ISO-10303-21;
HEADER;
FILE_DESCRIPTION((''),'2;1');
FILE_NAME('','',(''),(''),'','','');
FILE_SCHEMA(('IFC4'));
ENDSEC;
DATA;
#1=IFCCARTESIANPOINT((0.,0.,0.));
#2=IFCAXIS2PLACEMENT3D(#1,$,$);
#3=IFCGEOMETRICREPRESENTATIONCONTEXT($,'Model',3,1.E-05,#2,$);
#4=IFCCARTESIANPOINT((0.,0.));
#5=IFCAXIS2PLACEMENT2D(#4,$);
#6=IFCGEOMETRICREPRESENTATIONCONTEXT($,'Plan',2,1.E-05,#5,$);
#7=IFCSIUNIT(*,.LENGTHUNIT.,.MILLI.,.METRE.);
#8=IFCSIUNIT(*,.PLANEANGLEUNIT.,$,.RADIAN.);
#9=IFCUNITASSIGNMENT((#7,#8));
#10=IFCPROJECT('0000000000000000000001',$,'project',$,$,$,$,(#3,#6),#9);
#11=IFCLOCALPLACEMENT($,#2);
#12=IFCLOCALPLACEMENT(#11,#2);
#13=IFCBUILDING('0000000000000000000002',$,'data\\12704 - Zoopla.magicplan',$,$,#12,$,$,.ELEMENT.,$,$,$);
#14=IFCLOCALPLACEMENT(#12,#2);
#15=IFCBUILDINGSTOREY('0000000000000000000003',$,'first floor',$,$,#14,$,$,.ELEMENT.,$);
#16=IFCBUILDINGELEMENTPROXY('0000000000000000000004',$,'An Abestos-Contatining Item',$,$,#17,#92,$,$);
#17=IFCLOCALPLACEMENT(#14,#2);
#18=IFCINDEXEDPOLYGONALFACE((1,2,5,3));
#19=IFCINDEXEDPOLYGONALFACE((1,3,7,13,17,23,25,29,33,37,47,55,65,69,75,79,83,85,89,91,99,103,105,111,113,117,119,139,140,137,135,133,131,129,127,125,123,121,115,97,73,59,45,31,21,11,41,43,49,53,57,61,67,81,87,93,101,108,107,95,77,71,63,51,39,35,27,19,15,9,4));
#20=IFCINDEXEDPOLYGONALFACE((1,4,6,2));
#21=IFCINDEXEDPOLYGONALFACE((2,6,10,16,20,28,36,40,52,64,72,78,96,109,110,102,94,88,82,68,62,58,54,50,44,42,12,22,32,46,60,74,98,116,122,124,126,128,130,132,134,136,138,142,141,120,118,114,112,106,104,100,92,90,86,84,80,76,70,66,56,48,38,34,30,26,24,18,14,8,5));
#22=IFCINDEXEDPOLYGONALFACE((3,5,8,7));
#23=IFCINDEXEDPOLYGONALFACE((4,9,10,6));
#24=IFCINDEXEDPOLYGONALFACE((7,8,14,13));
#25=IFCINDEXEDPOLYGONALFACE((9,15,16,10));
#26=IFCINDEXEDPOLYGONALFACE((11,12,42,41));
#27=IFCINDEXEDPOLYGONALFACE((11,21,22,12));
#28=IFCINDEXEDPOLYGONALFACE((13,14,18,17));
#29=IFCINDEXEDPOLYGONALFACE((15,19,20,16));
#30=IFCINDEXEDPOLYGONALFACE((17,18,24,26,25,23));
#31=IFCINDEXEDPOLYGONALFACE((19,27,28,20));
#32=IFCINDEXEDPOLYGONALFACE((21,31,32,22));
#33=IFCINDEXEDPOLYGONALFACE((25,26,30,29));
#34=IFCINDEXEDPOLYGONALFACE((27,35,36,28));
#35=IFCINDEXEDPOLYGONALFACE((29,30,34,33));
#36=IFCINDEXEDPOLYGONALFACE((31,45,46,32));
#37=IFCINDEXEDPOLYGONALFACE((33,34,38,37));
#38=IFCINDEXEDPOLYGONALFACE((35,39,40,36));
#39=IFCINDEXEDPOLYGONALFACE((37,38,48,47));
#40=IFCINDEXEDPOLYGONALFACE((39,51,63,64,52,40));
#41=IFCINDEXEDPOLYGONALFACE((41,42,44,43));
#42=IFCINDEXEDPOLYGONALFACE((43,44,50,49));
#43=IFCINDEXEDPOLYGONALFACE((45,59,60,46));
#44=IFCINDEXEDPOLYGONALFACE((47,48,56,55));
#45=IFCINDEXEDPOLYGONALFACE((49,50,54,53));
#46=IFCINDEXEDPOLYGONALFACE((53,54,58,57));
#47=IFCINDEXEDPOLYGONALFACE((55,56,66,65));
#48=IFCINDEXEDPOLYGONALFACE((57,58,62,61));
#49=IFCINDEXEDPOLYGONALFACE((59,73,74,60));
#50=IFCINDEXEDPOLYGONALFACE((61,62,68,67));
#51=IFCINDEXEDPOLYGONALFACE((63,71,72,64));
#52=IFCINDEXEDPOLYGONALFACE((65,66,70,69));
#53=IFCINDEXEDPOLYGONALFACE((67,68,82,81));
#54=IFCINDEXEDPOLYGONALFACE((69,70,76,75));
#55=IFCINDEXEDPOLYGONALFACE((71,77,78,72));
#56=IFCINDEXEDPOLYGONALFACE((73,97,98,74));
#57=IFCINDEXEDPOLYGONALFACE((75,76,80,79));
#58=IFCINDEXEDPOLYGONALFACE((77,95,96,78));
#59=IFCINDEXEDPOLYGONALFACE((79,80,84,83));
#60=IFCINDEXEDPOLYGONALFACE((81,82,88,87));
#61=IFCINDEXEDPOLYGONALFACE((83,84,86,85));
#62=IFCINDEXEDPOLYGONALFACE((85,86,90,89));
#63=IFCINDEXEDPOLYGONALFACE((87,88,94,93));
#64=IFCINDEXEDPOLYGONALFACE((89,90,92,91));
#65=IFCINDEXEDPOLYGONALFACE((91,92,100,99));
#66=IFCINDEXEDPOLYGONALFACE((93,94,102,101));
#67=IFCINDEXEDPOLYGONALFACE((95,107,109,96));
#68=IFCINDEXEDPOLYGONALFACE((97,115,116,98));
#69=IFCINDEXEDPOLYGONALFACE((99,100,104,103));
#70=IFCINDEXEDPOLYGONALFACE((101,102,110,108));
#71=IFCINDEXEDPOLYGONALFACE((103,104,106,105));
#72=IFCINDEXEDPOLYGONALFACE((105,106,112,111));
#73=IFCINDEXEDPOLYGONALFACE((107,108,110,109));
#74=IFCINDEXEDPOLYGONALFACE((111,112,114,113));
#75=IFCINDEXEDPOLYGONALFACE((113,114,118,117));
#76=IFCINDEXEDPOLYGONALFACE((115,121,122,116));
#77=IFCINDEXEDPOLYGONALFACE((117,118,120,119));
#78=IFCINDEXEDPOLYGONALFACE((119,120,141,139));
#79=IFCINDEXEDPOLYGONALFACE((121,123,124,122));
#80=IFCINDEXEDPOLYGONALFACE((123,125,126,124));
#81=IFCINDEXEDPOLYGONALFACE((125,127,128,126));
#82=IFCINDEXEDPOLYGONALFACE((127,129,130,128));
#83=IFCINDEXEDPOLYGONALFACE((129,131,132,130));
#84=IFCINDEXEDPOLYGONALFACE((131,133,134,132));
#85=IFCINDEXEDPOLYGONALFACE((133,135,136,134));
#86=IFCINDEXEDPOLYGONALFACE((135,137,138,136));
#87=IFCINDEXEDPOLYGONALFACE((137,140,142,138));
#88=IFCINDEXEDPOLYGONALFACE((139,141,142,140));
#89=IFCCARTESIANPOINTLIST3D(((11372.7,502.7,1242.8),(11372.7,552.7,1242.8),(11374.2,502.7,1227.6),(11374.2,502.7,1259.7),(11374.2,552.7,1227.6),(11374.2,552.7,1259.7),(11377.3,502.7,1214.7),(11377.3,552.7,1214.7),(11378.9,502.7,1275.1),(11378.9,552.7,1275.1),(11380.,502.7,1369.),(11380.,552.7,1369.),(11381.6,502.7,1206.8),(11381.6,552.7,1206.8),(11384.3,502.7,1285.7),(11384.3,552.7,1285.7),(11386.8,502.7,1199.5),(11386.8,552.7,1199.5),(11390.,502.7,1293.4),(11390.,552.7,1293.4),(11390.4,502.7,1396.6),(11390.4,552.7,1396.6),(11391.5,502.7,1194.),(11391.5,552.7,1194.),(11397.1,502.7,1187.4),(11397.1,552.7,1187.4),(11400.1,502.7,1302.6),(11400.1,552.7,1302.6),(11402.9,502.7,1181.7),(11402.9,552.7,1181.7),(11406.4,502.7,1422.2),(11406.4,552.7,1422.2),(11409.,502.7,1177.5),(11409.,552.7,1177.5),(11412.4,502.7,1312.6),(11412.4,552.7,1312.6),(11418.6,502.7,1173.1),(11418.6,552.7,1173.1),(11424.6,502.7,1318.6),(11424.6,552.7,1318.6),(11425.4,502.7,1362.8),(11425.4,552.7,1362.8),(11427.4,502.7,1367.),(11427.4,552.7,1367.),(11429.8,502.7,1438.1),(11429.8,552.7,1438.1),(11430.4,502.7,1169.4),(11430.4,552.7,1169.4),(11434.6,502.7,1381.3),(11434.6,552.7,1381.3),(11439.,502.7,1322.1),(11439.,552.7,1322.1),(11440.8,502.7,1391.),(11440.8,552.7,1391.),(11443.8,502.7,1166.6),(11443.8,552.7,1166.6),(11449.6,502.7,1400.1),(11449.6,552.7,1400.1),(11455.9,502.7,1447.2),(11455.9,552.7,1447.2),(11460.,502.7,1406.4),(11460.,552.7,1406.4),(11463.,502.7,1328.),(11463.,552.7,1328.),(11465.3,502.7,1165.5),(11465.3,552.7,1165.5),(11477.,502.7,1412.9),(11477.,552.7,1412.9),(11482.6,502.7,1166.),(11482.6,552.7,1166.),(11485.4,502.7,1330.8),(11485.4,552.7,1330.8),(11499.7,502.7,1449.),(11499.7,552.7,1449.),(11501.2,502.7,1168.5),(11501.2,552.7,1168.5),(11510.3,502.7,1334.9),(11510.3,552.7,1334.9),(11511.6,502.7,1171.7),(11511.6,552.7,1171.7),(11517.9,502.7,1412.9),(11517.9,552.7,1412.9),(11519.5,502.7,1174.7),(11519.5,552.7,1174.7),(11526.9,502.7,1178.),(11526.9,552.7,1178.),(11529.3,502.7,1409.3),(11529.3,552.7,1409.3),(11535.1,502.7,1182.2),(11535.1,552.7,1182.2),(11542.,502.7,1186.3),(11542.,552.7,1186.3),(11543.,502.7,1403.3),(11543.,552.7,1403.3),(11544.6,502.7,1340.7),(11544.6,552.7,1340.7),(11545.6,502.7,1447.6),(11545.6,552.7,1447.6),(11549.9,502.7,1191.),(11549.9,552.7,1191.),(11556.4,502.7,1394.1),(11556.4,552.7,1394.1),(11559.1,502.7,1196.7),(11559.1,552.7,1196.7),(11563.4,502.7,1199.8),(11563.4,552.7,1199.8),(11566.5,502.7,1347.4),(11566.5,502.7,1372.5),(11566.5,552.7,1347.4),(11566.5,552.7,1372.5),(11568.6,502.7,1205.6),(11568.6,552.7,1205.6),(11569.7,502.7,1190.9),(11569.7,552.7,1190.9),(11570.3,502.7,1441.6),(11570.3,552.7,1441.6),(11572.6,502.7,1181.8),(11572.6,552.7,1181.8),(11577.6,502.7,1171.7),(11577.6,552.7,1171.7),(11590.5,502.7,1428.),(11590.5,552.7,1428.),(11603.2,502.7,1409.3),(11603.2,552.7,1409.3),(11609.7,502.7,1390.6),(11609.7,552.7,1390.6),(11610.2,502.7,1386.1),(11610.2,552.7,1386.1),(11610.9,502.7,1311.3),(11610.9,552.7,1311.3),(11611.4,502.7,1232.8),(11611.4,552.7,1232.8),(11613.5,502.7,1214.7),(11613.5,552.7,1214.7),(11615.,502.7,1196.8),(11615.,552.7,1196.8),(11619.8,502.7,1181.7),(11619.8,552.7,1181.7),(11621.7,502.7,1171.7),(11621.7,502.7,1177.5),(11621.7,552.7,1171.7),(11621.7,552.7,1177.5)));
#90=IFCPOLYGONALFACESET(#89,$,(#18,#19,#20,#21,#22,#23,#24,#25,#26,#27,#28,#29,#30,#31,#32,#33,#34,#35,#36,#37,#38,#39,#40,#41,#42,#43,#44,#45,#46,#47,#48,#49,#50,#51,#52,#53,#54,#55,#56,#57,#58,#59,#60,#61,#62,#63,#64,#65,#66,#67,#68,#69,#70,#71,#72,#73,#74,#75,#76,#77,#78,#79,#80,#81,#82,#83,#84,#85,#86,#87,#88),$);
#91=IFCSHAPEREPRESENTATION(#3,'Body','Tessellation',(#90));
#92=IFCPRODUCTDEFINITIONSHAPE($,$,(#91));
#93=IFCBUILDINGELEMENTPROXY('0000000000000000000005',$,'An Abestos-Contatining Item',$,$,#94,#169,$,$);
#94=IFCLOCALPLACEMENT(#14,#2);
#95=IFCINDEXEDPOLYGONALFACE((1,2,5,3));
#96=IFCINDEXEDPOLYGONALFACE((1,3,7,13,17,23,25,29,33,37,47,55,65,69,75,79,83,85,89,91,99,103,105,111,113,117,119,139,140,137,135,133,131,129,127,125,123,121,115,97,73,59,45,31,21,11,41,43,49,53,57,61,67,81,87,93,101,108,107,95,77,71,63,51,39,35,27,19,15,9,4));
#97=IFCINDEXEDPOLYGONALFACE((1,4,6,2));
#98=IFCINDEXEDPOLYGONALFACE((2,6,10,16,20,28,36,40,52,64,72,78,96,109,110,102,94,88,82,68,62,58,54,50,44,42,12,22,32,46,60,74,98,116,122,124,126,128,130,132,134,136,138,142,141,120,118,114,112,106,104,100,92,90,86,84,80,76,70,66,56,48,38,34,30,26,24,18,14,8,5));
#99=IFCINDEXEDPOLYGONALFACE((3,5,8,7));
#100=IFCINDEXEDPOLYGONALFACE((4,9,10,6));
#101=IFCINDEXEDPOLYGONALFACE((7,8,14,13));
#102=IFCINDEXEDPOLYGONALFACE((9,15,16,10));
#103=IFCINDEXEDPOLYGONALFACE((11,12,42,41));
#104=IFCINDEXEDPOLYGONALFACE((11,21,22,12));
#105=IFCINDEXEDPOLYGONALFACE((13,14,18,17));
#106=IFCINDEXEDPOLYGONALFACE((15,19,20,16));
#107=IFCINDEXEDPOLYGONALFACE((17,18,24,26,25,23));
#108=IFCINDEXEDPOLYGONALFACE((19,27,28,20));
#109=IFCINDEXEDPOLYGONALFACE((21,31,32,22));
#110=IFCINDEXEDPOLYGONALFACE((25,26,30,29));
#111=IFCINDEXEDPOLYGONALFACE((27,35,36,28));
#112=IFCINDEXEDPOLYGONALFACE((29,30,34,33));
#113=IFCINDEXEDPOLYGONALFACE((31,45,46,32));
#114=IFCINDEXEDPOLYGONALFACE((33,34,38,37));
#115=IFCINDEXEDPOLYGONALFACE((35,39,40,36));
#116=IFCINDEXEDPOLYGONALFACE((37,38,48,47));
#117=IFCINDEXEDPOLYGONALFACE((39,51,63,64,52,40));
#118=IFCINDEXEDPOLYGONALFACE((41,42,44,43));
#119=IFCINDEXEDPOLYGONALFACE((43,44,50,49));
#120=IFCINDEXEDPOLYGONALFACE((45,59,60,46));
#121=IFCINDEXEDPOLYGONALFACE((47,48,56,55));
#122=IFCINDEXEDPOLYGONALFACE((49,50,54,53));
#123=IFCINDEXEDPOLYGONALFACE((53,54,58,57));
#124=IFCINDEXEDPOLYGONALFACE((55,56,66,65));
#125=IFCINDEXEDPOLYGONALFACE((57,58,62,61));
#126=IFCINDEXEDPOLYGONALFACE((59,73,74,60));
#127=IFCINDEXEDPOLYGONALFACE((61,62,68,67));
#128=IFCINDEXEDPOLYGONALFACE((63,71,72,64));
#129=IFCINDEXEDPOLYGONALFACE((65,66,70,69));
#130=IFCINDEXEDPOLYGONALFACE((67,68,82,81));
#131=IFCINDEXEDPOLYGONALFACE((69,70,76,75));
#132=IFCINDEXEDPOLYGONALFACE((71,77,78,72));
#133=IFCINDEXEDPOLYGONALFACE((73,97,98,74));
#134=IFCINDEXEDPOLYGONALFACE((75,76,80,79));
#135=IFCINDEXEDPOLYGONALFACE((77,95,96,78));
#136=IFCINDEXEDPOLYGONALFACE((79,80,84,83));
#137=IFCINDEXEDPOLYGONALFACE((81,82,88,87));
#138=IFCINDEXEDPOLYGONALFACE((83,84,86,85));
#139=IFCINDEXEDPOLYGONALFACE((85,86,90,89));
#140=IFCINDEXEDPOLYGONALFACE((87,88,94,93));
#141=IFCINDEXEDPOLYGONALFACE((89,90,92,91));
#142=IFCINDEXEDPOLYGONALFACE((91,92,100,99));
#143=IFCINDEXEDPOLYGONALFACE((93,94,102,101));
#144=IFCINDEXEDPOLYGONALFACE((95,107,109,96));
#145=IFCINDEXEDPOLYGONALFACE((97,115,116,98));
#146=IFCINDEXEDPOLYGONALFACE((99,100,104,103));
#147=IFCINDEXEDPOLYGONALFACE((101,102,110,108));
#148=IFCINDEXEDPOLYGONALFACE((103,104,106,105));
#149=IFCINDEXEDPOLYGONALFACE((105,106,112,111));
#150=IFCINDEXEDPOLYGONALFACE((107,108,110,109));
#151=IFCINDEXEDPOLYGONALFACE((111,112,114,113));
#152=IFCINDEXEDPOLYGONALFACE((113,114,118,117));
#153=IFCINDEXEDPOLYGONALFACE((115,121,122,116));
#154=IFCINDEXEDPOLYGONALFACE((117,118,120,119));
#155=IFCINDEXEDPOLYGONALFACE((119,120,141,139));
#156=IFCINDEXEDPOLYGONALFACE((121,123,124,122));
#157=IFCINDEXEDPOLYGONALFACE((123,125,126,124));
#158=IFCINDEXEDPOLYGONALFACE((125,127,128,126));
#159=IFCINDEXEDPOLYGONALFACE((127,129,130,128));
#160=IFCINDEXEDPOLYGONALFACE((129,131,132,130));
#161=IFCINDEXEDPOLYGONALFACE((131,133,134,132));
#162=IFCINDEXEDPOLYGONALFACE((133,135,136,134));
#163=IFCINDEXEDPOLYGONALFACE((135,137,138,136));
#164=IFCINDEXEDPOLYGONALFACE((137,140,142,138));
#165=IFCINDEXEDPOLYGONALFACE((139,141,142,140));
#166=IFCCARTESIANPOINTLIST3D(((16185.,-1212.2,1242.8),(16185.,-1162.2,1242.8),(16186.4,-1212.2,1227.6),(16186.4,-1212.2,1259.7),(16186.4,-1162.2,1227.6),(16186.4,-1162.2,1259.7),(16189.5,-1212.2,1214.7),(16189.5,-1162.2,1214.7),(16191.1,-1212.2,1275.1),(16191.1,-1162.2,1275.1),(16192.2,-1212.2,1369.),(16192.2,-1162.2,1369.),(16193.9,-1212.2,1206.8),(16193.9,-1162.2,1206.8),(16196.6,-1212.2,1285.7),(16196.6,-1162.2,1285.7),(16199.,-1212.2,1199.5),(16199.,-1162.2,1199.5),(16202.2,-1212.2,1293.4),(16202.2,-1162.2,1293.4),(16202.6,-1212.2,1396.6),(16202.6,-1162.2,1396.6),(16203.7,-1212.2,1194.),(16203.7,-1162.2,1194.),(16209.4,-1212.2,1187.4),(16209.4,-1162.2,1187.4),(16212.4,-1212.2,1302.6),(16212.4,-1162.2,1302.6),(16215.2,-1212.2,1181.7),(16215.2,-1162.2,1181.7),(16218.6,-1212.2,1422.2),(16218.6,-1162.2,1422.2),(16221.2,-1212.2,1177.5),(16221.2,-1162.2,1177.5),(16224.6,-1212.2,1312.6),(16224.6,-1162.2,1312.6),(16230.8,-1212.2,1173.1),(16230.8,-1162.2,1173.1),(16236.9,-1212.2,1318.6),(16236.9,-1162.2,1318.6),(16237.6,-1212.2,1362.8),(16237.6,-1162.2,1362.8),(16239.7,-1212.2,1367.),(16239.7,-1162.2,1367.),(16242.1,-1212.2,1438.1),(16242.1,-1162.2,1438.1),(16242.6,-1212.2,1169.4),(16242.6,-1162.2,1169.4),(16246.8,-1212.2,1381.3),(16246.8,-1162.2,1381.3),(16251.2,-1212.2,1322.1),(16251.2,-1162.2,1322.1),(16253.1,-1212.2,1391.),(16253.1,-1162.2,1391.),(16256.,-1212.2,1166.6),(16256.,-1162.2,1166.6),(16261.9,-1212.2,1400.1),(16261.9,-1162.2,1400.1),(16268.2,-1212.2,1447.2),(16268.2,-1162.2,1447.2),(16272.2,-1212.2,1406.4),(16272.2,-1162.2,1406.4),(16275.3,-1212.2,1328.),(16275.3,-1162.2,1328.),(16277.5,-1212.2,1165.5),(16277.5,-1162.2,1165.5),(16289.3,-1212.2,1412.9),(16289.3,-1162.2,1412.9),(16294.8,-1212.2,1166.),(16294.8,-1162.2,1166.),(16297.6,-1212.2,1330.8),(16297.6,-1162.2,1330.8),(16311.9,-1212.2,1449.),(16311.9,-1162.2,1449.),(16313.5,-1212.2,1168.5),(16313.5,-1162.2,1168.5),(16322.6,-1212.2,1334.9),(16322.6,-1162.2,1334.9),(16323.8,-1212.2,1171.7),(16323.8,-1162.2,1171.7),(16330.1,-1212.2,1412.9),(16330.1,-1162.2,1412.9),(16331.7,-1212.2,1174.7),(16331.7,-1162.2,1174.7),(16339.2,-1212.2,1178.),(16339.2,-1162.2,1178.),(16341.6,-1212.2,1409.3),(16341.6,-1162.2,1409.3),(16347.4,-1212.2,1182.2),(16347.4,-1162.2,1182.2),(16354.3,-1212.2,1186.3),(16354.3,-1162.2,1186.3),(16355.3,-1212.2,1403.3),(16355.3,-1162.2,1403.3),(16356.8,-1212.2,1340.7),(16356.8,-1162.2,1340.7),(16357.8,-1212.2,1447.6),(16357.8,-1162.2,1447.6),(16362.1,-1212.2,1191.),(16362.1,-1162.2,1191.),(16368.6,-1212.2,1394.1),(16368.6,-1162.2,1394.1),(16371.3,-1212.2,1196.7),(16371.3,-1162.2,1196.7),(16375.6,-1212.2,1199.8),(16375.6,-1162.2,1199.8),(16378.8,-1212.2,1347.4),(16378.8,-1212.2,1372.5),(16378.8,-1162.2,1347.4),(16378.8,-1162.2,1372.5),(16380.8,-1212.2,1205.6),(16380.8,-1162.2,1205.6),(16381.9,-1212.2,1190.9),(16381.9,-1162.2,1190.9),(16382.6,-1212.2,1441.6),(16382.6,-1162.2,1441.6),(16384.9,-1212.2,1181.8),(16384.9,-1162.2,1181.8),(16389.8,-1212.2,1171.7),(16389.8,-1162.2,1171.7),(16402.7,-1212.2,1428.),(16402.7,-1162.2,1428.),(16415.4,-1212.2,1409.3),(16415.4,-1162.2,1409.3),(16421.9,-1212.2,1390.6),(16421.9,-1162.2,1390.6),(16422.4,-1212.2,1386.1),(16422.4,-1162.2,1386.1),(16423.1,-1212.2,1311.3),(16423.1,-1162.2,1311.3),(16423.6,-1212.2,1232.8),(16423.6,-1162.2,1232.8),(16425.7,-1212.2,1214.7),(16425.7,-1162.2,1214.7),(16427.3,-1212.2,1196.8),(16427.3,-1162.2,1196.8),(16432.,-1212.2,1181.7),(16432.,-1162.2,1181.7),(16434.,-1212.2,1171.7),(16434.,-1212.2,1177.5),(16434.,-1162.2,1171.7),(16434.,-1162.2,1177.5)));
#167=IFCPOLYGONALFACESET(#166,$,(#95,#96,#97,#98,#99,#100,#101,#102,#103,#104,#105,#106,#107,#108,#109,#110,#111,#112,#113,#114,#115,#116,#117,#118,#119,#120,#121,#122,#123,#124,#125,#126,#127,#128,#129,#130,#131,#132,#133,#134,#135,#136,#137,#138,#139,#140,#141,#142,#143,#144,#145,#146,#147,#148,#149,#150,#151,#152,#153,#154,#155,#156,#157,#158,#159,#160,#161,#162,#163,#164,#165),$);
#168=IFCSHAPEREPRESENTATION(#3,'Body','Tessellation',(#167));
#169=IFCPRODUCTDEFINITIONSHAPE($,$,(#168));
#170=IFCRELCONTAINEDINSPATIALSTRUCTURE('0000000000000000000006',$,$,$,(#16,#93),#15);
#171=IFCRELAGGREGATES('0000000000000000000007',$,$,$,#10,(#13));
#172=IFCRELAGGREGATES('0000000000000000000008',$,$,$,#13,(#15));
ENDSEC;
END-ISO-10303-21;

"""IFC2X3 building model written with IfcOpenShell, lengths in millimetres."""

from ifc_helpers import new_model, si_unit, frame, origin, origin_2d, place, context, project, spatial, polyline, outline, extrude, element, save


model = new_model("IFC2X3")

# Units and contexts
model_context = context("Model", 3, precision=1e-05, world=origin())
plan_context = context("Plan", 2, precision=1e-05, world=origin_2d())
ifc_project = project(units=[si_unit("LENGTHUNIT", "METRE", prefix="MILLI"), si_unit("PLANEANGLEUNIT", "RADIAN")], contexts=[model_context, plan_context])

# Building, storey
placement_1 = place(None, origin())
building_placement = place(placement_1, origin())
building = spatial("IfcBuilding", under=ifc_project, at=building_placement, Name="data\\12704 - Zoopla.magicplan", CompositionType="ELEMENT")
storey_placement = place(building_placement, origin())
storey = spatial("IfcBuildingStorey", under=building, at=storey_placement, Name="first floor", CompositionType="ELEMENT")

# Building element proxies
placement_2 = place(None, frame((12448.2, -975.8, 0.0)))
proxy_1_placement = place(placement_2, frame((-1076.5, 1528.5, 1165.0)))
element("IfcBuildingElementProxy", 1, at=proxy_1_placement, inside=storey, Name="An Abestos-Contatining Item", context=model_context, shape_type="SurfaceModel", body=[
    extrude(outline(polyline([(239.2, 0.0, 146.3), (239.7, 0.0, 67.8), (241.8, 0.0, 49.7), (243.3, 0.0, 31.9), (248.1, 0.0, 16.7), (250.0, 0.0, 12.5), (250.0, 0.0, 6.7), (205.8, 0.0, 6.7), (200.9, 0.0, 16.8), (197.9, 0.0, 25.9), (196.9, 0.0, 40.6), (191.6, 0.0, 34.8), (187.3, 0.0, 31.7), (178.2, 0.0, 26.0), (170.3, 0.0, 21.3), (163.4, 0.0, 17.2), (155.2, 0.0, 13.0), (147.8, 0.0, 9.7), (139.9, 0.0, 6.7), (129.5, 0.0, 3.5), (110.9, 0.0, 1.0), (93.6, 0.0, 0.5), (72.1, 0.0, 1.6), (58.6, 0.0, 4.4), (46.9, 0.0, 8.1), (37.3, 0.0, 12.5), (31.2, 0.0, 16.7), (25.4, 0.0, 22.4), (19.8, 0.0, 29.0), (15.1, 0.0, 34.5), (9.9, 0.0, 41.9), (5.5, 0.0, 49.7), (2.5, 0.0, 62.6), (1.0, 0.0, 77.8), (2.5, 0.0, 94.7), (7.2, 0.0, 110.1), (12.6, 0.0, 120.7), (18.2, 0.0, 128.4), (28.4, 0.0, 137.6), (40.7, 0.0, 147.6), (52.9, 0.0, 153.6), (67.3, 0.0, 157.1), (91.3, 0.0, 163.0), (113.7, 0.0, 165.8), (138.6, 0.0, 169.9), (172.9, 0.0, 175.7), (194.8, 0.0, 182.4), (194.8, 0.0, 207.5), (184.7, 0.0, 229.1), (171.3, 0.0, 238.3), (157.6, 0.0, 244.3), (146.2, 0.0, 247.9), (105.3, 0.0, 247.9), (88.3, 0.0, 241.4), (77.9, 0.0, 235.1), (69.1, 0.0, 226.0), (62.9, 0.0, 216.3), (55.7, 0.0, 202.0), (53.6, 0.0, 197.8), (8.2, 0.0, 204.0), (18.7, 0.0, 231.7), (34.6, 0.0, 257.2), (58.1, 0.0, 273.1), (84.2, 0.0, 282.2), (128.0, 0.0, 284.0), (173.9, 0.0, 282.6), (198.6, 0.0, 276.6), (218.8, 0.0, 263.1), (231.4, 0.0, 244.3), (238.0, 0.0, 225.6), (238.5, 0.0, 221.1)]), holes=[polyline([(193.0, 0.0, 144.2), (193.0, 0.0, 117.7), (190.5, 0.0, 97.8), (183.8, 0.0, 80.4), (174.2, 0.0, 64.5), (165.3, 0.0, 54.4), (152.5, 0.0, 47.3), (138.0, 0.0, 41.5), (124.6, 0.0, 37.8), (85.5, 0.0, 37.8), (75.0, 0.0, 41.4), (65.8, 0.0, 47.1), (57.8, 0.0, 55.4), (52.1, 0.0, 66.4), (49.5, 0.0, 74.4), (49.5, 0.0, 88.6), (55.3, 0.0, 100.7), (65.3, 0.0, 109.9), (81.0, 0.0, 119.8), (101.0, 0.0, 125.3), (119.9, 0.0, 128.5), (146.8, 0.0, 131.5), (165.0, 0.0, 134.9), (179.8, 0.0, 140.1), (193.0, 0.0, 144.2)])], kind="CURVE"), origin(), (0.0, -1.0, 0.0), 50.0),
])
placement_3 = place(None, frame((16081.4, -589.1, 0.0)))
proxy_2_placement = place(placement_3, frame((102.6, -573.1, 1165.0)))
element("IfcBuildingElementProxy", 2, at=proxy_2_placement, inside=storey, Name="An Abestos-Contatining Item", context=model_context, shape_type="SurfaceModel", body=[
    extrude(outline(polyline([(239.2, 0.0, 146.3), (239.7, 0.0, 67.8), (241.8, 0.0, 49.7), (243.3, 0.0, 31.9), (248.1, 0.0, 16.7), (250.0, 0.0, 12.5), (250.0, 0.0, 6.7), (205.8, 0.0, 6.7), (200.9, 0.0, 16.8), (197.9, 0.0, 25.9), (196.9, 0.0, 40.6), (191.6, 0.0, 34.8), (187.3, 0.0, 31.7), (178.2, 0.0, 26.0), (170.3, 0.0, 21.3), (163.4, 0.0, 17.2), (155.2, 0.0, 13.0), (147.8, 0.0, 9.7), (139.9, 0.0, 6.7), (129.5, 0.0, 3.5), (110.9, 0.0, 1.0), (93.6, 0.0, 0.5), (72.1, 0.0, 1.6), (58.6, 0.0, 4.4), (46.9, 0.0, 8.1), (37.3, 0.0, 12.5), (31.2, 0.0, 16.7), (25.4, 0.0, 22.4), (19.8, 0.0, 29.0), (15.1, 0.0, 34.5), (9.9, 0.0, 41.9), (5.5, 0.0, 49.7), (2.5, 0.0, 62.6), (1.0, 0.0, 77.8), (2.5, 0.0, 94.7), (7.2, 0.0, 110.1), (12.6, 0.0, 120.7), (18.2, 0.0, 128.4), (28.4, 0.0, 137.6), (40.7, 0.0, 147.6), (52.9, 0.0, 153.6), (67.3, 0.0, 157.1), (91.3, 0.0, 163.0), (113.7, 0.0, 165.8), (138.6, 0.0, 169.9), (172.9, 0.0, 175.7), (194.8, 0.0, 182.4), (194.8, 0.0, 207.5), (184.7, 0.0, 229.1), (171.3, 0.0, 238.3), (157.6, 0.0, 244.3), (146.2, 0.0, 247.9), (105.3, 0.0, 247.9), (88.3, 0.0, 241.4), (77.9, 0.0, 235.1), (69.1, 0.0, 226.0), (62.9, 0.0, 216.3), (55.7, 0.0, 202.0), (53.6, 0.0, 197.8), (8.2, 0.0, 204.0), (18.7, 0.0, 231.7), (34.6, 0.0, 257.2), (58.1, 0.0, 273.1), (84.2, 0.0, 282.2), (128.0, 0.0, 284.0), (173.9, 0.0, 282.6), (198.6, 0.0, 276.6), (218.8, 0.0, 263.1), (231.4, 0.0, 244.3), (238.0, 0.0, 225.6), (238.5, 0.0, 221.1)]), holes=[polyline([(193.0, 0.0, 144.2), (193.0, 0.0, 117.7), (190.5, 0.0, 97.8), (183.8, 0.0, 80.4), (174.2, 0.0, 64.5), (165.3, 0.0, 54.4), (152.5, 0.0, 47.3), (138.0, 0.0, 41.5), (124.6, 0.0, 37.8), (85.5, 0.0, 37.8), (75.0, 0.0, 41.4), (65.8, 0.0, 47.1), (57.8, 0.0, 55.4), (52.1, 0.0, 66.4), (49.5, 0.0, 74.4), (49.5, 0.0, 88.6), (55.3, 0.0, 100.7), (65.3, 0.0, 109.9), (81.0, 0.0, 119.8), (101.0, 0.0, 125.3), (119.9, 0.0, 128.5), (146.8, 0.0, 131.5), (165.0, 0.0, 134.9), (179.8, 0.0, 140.1), (193.0, 0.0, 144.2)])], kind="CURVE"), origin(), (0.0, -1.0, 0.0), 50.0),
])

save(model, "model.ifc")
